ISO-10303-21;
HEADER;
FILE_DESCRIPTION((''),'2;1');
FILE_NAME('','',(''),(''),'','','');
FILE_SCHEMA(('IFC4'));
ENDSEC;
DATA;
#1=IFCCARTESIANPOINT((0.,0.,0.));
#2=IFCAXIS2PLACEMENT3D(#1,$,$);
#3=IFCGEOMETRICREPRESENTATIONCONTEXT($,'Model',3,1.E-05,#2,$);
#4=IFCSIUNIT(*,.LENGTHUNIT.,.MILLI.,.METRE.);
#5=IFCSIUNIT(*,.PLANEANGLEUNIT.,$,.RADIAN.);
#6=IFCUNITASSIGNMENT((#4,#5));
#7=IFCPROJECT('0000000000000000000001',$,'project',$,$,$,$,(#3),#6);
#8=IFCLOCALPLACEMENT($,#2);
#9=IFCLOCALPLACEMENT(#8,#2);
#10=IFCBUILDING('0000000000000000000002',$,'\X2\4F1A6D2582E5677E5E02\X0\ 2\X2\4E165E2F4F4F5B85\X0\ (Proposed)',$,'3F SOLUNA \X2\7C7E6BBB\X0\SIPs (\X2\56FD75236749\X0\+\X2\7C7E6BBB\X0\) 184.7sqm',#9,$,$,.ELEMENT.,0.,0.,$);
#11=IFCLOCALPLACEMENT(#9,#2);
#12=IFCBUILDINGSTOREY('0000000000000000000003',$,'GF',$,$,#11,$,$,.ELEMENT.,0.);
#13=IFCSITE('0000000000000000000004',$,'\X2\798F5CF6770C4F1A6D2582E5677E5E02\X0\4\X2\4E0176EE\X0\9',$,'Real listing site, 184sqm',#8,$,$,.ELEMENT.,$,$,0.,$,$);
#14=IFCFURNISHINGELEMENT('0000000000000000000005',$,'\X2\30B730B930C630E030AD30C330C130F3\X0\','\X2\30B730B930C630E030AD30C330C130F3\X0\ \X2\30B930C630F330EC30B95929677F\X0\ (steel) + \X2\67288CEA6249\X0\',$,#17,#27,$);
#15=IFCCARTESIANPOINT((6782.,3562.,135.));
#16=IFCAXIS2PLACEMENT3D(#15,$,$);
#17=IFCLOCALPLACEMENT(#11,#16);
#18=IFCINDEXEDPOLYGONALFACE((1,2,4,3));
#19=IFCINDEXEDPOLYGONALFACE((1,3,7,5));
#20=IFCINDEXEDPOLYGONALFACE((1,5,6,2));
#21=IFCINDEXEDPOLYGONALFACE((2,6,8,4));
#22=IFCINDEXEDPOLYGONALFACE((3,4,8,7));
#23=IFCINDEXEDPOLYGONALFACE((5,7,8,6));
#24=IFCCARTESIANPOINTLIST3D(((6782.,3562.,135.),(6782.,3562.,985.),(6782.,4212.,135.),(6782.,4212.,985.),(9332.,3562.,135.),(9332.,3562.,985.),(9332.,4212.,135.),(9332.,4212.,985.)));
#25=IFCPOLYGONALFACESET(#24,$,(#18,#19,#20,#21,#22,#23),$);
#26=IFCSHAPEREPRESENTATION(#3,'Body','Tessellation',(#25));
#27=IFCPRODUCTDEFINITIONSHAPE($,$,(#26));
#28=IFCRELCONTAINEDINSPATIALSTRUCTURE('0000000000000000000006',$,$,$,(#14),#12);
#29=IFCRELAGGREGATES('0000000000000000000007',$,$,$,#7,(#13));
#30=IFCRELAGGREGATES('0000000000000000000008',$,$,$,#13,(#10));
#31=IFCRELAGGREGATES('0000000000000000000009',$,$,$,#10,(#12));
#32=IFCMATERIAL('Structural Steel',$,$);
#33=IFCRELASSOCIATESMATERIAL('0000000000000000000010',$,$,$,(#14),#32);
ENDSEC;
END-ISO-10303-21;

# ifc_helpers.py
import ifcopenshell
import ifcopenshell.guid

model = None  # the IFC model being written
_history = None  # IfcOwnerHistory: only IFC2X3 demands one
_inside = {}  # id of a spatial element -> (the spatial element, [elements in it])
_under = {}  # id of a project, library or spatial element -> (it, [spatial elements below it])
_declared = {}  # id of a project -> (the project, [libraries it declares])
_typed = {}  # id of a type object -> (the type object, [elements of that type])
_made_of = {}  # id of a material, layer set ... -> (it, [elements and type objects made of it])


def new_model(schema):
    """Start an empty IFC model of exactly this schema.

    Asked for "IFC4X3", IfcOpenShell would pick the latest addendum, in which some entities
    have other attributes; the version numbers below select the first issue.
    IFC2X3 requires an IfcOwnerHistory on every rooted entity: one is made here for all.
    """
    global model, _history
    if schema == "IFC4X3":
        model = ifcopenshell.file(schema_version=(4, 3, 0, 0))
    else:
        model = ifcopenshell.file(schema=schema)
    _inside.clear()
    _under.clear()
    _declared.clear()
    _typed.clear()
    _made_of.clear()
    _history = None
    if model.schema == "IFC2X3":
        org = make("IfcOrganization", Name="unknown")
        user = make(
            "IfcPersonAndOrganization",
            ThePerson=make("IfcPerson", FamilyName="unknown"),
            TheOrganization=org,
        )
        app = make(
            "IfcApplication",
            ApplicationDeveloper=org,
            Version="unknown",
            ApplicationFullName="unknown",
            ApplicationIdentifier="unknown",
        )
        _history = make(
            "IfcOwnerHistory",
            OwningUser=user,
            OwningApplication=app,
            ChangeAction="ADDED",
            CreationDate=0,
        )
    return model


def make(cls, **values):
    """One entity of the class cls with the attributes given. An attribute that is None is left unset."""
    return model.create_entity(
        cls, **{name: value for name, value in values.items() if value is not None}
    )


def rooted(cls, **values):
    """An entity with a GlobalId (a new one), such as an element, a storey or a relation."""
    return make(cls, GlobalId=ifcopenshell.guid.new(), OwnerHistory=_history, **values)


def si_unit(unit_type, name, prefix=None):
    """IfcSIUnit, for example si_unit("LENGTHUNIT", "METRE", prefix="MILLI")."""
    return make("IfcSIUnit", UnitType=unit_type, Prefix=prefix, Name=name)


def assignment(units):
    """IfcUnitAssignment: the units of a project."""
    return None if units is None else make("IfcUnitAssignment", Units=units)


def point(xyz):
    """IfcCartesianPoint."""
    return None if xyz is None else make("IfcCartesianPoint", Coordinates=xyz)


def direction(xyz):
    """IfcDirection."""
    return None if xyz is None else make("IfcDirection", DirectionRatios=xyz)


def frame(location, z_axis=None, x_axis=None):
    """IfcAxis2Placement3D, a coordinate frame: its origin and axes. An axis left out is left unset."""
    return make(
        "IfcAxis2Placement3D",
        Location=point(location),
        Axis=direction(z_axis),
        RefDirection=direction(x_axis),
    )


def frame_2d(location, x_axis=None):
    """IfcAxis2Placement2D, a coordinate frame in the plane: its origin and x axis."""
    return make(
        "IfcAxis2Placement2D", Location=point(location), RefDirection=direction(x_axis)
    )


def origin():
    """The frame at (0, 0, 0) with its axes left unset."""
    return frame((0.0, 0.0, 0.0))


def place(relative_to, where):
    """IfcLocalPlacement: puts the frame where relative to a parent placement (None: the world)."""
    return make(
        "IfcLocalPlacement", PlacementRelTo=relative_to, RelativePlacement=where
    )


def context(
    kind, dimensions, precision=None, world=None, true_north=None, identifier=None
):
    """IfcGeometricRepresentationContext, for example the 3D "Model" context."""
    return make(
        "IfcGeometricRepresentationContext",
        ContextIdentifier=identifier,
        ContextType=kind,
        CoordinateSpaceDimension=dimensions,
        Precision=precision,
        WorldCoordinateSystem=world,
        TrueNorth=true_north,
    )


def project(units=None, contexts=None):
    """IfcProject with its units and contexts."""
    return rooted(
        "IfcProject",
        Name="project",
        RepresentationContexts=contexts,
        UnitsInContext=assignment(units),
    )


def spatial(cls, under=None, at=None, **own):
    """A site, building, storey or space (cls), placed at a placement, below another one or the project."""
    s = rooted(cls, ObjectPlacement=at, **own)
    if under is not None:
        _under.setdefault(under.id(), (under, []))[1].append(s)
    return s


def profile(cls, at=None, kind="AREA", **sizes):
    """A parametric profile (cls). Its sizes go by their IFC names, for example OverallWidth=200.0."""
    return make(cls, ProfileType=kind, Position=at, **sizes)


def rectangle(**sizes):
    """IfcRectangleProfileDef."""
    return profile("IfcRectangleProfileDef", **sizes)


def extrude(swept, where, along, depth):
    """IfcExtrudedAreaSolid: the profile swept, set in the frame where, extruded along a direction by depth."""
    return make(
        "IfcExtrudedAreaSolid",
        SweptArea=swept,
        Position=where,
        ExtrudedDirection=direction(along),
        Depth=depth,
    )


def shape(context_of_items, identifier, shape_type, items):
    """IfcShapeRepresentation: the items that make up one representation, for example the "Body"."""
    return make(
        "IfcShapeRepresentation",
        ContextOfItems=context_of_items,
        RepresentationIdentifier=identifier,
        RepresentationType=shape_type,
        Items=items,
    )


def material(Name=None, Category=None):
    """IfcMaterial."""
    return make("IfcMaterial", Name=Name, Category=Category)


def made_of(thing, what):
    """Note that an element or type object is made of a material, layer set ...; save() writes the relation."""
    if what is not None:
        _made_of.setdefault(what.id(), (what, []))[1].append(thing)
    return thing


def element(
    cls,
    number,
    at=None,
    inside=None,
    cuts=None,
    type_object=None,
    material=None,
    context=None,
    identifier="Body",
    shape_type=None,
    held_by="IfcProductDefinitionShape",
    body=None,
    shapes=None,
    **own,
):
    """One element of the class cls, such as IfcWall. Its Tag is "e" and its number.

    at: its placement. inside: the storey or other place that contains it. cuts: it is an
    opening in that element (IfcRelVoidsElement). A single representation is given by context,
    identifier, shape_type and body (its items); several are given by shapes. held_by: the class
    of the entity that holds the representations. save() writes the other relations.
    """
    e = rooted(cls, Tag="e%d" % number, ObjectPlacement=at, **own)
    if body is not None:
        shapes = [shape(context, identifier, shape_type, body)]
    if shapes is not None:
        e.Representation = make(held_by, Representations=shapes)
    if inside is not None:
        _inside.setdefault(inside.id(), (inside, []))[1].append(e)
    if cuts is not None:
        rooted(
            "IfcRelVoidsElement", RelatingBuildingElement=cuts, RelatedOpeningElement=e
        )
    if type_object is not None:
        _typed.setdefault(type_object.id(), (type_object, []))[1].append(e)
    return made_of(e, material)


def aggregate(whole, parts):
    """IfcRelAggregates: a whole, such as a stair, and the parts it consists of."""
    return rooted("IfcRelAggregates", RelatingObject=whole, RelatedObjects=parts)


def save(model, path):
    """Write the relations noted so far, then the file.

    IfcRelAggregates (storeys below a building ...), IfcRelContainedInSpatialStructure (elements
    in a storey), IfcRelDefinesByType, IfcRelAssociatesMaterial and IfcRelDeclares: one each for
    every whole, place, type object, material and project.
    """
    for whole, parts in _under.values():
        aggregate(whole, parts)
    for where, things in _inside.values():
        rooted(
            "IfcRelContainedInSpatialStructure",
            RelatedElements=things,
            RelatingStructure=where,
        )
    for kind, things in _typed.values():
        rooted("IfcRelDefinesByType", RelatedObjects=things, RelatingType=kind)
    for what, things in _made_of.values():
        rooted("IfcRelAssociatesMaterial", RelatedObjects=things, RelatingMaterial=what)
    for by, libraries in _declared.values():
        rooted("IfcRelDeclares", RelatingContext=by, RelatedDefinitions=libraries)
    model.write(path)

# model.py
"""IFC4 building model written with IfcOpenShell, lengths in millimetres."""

from ifc_helpers import new_model, si_unit, frame, frame_2d, origin, place, context, project, spatial, rectangle, extrude, material, element, save


model = new_model("IFC4")

# Units and contexts
model_context = context("Model", 3, precision=1e-05, world=origin())
ifc_project = project(units=[si_unit("LENGTHUNIT", "METRE", prefix="MILLI"), si_unit("PLANEANGLEUNIT", "RADIAN")], contexts=[model_context])

# Site, building, storey
site_placement = place(None, origin())
site = spatial("IfcSite", under=ifc_project, at=site_placement, Name="福島県会津若松市4丁目9", ObjectType="Real listing site, 184sqm", CompositionType="ELEMENT", RefElevation=0.0)
building_placement = place(site_placement, origin())
building = spatial("IfcBuilding", under=site, at=building_placement, Name="会津若松市 2世帯住宅 (Proposed)", ObjectType="3F SOLUNA 籾殻SIPs (国産杉+籾殻) 184.7sqm", CompositionType="ELEMENT", ElevationOfRefHeight=0.0, ElevationOfTerrain=0.0)
storey_placement = place(building_placement, origin())
storey = spatial("IfcBuildingStorey", under=building, at=storey_placement, Name="GF", CompositionType="ELEMENT", Elevation=0.0)

# Furnishing element
ifc_material_1 = material(Name="Structural Steel")
furnishing_1_placement = place(storey_placement, frame((6782.0, 3562.0, 135.0)))
element("IfcFurnishingElement", 1, at=furnishing_1_placement, inside=storey, material=ifc_material_1, Name="システムキッチン", Description="システムキッチン ステンレス天板 (steel) + 木質扉", context=model_context, shape_type="SweptSolid", body=[
    extrude(rectangle(XDim=2550.0, YDim=650.0, at=frame_2d((1275.0, 325.0))), frame((6782.0, 3562.0, 135.0)), (0.0, 0.0, 1.0), 850.0),
])

save(model, "model.ifc")
